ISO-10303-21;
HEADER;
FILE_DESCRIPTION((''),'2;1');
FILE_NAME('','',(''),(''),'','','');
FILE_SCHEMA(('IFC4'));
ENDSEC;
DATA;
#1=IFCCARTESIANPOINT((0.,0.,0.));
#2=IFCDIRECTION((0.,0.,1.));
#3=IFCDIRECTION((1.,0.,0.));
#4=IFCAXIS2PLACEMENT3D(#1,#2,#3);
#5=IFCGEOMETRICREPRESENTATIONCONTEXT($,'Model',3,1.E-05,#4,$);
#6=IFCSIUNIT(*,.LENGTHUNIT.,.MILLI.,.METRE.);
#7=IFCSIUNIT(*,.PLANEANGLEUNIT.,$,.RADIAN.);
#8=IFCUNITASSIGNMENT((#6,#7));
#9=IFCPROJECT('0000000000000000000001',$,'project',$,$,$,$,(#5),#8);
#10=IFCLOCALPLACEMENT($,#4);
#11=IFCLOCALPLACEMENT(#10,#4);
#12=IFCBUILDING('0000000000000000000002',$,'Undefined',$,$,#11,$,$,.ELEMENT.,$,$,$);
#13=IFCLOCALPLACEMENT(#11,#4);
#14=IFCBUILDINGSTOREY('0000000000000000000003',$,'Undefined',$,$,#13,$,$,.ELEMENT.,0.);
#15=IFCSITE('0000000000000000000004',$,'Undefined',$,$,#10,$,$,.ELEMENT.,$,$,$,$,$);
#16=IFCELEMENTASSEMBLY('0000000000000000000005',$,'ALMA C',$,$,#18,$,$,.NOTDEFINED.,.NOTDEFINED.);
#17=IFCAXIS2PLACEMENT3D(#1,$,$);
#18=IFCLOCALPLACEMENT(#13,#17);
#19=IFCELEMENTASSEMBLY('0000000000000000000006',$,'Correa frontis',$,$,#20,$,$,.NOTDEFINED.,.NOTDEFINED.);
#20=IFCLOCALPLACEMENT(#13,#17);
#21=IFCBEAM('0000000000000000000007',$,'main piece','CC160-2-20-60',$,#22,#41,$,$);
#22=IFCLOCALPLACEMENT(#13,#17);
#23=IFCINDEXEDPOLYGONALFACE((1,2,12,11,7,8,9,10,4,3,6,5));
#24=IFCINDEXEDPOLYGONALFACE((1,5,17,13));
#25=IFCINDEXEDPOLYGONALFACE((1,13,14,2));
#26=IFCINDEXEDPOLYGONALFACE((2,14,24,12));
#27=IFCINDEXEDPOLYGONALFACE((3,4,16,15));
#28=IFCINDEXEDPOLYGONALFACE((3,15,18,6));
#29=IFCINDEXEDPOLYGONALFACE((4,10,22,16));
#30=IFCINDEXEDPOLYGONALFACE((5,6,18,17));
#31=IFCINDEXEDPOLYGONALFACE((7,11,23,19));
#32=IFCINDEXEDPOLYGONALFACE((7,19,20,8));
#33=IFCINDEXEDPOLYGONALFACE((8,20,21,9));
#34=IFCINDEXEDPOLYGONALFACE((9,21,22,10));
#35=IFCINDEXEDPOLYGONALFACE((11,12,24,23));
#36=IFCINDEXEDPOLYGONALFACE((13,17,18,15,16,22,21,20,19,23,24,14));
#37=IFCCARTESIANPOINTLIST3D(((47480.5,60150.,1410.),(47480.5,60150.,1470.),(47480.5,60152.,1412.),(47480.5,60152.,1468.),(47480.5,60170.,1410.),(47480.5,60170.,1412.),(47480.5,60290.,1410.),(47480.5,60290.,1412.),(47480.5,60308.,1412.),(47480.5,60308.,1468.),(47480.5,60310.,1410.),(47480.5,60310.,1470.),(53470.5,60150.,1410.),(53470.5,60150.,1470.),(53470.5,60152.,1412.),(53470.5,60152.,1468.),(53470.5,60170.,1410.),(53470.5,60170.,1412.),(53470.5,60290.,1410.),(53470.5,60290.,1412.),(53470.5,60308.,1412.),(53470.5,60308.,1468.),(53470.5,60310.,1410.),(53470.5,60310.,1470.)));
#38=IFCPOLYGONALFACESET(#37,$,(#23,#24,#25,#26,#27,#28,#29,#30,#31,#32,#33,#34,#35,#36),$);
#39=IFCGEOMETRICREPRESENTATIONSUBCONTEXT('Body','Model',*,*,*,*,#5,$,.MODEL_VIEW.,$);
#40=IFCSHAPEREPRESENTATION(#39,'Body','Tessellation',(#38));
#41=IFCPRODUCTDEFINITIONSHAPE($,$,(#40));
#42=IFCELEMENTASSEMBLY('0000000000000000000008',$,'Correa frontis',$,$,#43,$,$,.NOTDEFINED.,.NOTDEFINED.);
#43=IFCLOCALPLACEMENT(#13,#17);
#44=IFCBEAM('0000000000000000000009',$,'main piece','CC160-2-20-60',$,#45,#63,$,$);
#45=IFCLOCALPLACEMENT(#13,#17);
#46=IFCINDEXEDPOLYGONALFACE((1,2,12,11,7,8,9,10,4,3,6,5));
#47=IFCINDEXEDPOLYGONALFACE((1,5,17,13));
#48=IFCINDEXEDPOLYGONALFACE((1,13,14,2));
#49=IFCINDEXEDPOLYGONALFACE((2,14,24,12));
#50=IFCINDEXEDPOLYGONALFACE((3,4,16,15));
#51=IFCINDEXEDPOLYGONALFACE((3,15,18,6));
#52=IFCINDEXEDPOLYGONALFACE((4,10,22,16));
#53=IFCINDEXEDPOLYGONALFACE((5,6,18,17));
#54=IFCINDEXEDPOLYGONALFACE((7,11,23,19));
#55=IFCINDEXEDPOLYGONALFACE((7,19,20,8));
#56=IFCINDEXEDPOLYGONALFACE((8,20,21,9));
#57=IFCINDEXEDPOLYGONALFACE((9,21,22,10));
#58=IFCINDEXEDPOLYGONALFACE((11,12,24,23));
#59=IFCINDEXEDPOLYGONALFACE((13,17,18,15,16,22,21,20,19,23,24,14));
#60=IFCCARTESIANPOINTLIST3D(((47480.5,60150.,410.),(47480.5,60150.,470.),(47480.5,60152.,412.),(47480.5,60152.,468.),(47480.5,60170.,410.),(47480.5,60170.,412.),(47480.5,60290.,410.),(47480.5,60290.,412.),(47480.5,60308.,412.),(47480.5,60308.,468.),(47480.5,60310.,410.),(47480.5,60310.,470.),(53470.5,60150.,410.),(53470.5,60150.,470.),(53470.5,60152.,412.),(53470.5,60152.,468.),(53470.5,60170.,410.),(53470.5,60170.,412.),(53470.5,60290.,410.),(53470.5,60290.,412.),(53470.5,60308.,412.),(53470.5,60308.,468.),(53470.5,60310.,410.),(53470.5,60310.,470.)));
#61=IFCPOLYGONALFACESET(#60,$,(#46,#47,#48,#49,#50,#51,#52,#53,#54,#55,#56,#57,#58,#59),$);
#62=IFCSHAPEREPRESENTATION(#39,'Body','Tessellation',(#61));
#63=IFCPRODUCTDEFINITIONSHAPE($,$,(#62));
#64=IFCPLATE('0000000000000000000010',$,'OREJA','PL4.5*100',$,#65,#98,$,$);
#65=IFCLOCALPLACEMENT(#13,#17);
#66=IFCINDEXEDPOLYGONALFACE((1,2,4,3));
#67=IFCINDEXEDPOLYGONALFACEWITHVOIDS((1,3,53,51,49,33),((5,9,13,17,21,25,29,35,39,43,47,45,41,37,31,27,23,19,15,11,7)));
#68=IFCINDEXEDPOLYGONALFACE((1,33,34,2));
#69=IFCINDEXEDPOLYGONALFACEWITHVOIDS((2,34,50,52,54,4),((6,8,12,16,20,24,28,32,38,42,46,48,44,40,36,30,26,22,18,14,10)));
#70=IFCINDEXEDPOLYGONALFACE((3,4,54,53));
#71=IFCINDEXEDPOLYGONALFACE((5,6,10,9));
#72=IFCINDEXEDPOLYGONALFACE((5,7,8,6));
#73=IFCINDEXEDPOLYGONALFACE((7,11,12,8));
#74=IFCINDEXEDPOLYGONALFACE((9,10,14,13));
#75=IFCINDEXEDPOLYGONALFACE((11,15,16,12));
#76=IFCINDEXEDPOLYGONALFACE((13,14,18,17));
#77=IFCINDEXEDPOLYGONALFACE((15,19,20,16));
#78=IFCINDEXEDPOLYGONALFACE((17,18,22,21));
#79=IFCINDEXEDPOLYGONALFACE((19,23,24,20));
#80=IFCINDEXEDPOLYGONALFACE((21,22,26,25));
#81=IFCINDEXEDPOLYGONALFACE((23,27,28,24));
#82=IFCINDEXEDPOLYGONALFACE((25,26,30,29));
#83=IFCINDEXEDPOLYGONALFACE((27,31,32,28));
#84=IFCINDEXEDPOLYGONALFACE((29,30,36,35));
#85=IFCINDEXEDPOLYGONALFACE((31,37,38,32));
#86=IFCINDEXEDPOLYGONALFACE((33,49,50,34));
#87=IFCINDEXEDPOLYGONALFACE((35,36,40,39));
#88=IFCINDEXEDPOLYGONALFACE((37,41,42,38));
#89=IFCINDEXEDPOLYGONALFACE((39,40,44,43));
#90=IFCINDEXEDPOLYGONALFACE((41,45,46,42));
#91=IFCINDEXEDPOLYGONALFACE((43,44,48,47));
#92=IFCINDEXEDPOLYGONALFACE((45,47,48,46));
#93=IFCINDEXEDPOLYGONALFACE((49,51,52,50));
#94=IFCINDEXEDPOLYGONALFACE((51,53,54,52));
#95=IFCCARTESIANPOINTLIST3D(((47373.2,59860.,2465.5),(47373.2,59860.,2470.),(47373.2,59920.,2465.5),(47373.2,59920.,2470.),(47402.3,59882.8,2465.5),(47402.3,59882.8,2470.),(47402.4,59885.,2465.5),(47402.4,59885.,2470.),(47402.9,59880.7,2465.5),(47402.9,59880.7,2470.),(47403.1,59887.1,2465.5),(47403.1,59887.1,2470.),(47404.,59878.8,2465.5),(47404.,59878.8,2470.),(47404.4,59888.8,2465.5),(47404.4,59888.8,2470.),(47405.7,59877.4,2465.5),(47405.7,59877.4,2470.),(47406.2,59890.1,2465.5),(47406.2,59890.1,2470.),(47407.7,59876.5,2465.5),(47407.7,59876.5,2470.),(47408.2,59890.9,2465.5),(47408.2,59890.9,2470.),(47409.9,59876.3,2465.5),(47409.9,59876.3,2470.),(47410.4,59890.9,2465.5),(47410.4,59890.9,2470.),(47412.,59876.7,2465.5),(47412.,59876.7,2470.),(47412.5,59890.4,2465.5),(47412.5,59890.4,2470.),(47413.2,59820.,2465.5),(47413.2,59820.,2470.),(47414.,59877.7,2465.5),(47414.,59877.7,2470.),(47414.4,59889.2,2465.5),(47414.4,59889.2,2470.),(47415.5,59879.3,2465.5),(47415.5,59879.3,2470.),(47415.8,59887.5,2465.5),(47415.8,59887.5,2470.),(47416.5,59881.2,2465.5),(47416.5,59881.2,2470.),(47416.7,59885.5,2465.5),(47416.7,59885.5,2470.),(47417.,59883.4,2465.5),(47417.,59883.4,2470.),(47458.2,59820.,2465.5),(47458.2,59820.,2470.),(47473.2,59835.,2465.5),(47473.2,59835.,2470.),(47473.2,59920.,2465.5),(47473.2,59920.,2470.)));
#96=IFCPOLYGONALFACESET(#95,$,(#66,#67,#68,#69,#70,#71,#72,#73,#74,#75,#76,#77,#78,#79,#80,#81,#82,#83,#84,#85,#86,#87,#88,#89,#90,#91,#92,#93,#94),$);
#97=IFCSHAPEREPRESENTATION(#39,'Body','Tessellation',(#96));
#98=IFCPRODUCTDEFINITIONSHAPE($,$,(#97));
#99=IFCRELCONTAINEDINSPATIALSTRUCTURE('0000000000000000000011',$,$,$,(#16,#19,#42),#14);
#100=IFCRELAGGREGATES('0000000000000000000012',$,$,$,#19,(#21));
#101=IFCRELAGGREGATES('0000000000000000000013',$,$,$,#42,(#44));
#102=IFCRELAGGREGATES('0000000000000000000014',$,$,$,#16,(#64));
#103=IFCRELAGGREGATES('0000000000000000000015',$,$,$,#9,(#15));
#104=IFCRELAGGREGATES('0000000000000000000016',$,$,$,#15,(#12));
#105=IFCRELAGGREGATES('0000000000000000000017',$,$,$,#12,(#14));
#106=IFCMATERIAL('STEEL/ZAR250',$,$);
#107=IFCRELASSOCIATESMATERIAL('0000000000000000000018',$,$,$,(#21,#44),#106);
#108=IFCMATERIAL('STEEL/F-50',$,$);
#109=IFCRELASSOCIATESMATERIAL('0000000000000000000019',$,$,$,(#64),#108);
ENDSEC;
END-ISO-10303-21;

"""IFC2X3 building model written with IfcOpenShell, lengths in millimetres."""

from ifc_helpers import new_model, si_unit, frame, origin_with_axes, origin_2d_with_axis, place, context, subcontext, project, spatial, polyline, circle, c_section, outline, extrude, source, transform, mapped, material, element, aggregate, save


model = new_model("IFC2X3")

# Units and contexts
model_context = context("Model", 3, precision=1e-05, world=origin_with_axes())
body_context = subcontext(model_context, "Body", "Model", "MODEL_VIEW")
ifc_project = project(units=[si_unit("LENGTHUNIT", "METRE", prefix="MILLI"), si_unit("PLANEANGLEUNIT", "RADIAN")], contexts=[model_context])

# Site, building, storey
site_placement = place(None, origin_with_axes())
site = spatial("IfcSite", under=ifc_project, at=site_placement, Name="Undefined", CompositionType="ELEMENT")
building_placement = place(site_placement, origin_with_axes())
building = spatial("IfcBuilding", under=site, at=building_placement, Name="Undefined", CompositionType="ELEMENT")
storey_placement = place(building_placement, origin_with_axes())
storey = spatial("IfcBuildingStorey", under=building, at=storey_placement, Name="Undefined", CompositionType="ELEMENT", Elevation=0.0)

# Element assembly
assembly_1_placement = place(storey_placement, origin_with_axes())
assembly_1 = element("IfcElementAssembly", 1, at=assembly_1_placement, inside=storey, Name="ALMA C", AssemblyPlace="NOTDEFINED", PredefinedType="NOTDEFINED")

# Shared definitions
ifc_material_1 = material(Name="STEEL/F-50")

# Element assemblies, beams
ifc_material_2 = material(Name="STEEL/ZAR250")
assembly_2_placement = place(storey_placement, origin_with_axes())
assembly_2 = element("IfcElementAssembly", 2, at=assembly_2_placement, inside=storey, Name="Correa frontis", AssemblyPlace="NOTDEFINED", PredefinedType="NOTDEFINED")
beam_1_placement = place(assembly_2_placement, frame((47480.5, 60230.0, 1440.0), z_axis=(0.0, -1.0, 0.0), x_axis=(1.0, 0.0, 0.0)))
beam_1 = element("IfcBeam", 3, at=beam_1_placement, material=ifc_material_2, Name="main piece", Description="CC160-2-20-60", context=body_context, shape_type="SweptSolid", body=[
    extrude(c_section(Depth=160.0, Width=60.0, WallThickness=2.0, Girth=20.0, at=origin_2d_with_axis()), frame((5990.0, 0.0, 0.0), z_axis=(-1.0, 0.0, 0.0), x_axis=(0.0, -1.0, 0.0)), (0.0, 0.0, 1.0), 5990.0),
])
aggregate(assembly_2, [beam_1])
assembly_3_placement = place(storey_placement, origin_with_axes())
assembly_3 = element("IfcElementAssembly", 4, at=assembly_3_placement, inside=storey, Name="Correa frontis", AssemblyPlace="NOTDEFINED", PredefinedType="NOTDEFINED")
beam_2_placement = place(assembly_3_placement, frame((47480.5, 60230.0, 440.0), z_axis=(0.0, -1.0, 0.0), x_axis=(1.0, 0.0, 0.0)))
beam_2 = element("IfcBeam", 5, at=beam_2_placement, material=ifc_material_2, Name="main piece", Description="CC160-2-20-60", context=body_context, shape_type="SweptSolid", body=[
    extrude(c_section(Depth=160.0, Width=60.0, WallThickness=2.0, Girth=20.0, at=origin_2d_with_axis()), frame((5990.0, 0.0, 0.0), z_axis=(-1.0, 0.0, 0.0), x_axis=(0.0, -1.0, 0.0)), (0.0, 0.0, 1.0), 5990.0),
])
aggregate(assembly_3, [beam_2])

# Plate, opening
plate_1_placement = place(assembly_1_placement, frame((47473.2, 59820.0, 2467.8), z_axis=(0.0, 0.0, -1.0), x_axis=(-1.0, 0.0, 0.0)))
plate_1 = element("IfcPlate", 6, at=plate_1_placement, material=ifc_material_1, Name="OREJA", Description="PL4.5*100", context=body_context, shape_type="SweptSolid", body=[
    extrude(outline(polyline([(0.0, 15.0), (15.0, 0.0), (60.0, 0.0), (100.0, 40.0), (100.0, 100.0), (0.0, 100.0), (0.0, 15.0)])), frame((0.0, 0.0, -2.2), z_axis=(0.0, 0.0, 1.0), x_axis=(1.0, 0.0, 0.0)), (0.0, 0.0, 1.0), 4.5),
])
shared_shape_1 = source(origin_with_axes(), body_context, "Body", "SweptSolid", [
    extrude(circle(Radius=7.3, at=origin_2d_with_axis()), frame((0.0, -0.1, 0.0), z_axis=(0.0, 1.0, 0.0), x_axis=(1.0, 0.0, 0.0)), (0.0, 0.0, 1.0), 4.7),
])
opening_1_placement = place(assembly_1_placement, frame((47409.6, 59883.6, 2470.0), z_axis=(-0.707107, -0.707107, 0.0), x_axis=(-0.707107, 0.707107, 0.0)))
element("IfcOpeningElement", 7, at=opening_1_placement, cuts=plate_1, ObjectType="Opening", context=body_context, shape_type="MappedRepresentation", body=[
    mapped(shared_shape_1, transform((0.0, 0.0, 0.0))),
])

aggregate(assembly_1, [plate_1])

save(model, "model.ifc")
